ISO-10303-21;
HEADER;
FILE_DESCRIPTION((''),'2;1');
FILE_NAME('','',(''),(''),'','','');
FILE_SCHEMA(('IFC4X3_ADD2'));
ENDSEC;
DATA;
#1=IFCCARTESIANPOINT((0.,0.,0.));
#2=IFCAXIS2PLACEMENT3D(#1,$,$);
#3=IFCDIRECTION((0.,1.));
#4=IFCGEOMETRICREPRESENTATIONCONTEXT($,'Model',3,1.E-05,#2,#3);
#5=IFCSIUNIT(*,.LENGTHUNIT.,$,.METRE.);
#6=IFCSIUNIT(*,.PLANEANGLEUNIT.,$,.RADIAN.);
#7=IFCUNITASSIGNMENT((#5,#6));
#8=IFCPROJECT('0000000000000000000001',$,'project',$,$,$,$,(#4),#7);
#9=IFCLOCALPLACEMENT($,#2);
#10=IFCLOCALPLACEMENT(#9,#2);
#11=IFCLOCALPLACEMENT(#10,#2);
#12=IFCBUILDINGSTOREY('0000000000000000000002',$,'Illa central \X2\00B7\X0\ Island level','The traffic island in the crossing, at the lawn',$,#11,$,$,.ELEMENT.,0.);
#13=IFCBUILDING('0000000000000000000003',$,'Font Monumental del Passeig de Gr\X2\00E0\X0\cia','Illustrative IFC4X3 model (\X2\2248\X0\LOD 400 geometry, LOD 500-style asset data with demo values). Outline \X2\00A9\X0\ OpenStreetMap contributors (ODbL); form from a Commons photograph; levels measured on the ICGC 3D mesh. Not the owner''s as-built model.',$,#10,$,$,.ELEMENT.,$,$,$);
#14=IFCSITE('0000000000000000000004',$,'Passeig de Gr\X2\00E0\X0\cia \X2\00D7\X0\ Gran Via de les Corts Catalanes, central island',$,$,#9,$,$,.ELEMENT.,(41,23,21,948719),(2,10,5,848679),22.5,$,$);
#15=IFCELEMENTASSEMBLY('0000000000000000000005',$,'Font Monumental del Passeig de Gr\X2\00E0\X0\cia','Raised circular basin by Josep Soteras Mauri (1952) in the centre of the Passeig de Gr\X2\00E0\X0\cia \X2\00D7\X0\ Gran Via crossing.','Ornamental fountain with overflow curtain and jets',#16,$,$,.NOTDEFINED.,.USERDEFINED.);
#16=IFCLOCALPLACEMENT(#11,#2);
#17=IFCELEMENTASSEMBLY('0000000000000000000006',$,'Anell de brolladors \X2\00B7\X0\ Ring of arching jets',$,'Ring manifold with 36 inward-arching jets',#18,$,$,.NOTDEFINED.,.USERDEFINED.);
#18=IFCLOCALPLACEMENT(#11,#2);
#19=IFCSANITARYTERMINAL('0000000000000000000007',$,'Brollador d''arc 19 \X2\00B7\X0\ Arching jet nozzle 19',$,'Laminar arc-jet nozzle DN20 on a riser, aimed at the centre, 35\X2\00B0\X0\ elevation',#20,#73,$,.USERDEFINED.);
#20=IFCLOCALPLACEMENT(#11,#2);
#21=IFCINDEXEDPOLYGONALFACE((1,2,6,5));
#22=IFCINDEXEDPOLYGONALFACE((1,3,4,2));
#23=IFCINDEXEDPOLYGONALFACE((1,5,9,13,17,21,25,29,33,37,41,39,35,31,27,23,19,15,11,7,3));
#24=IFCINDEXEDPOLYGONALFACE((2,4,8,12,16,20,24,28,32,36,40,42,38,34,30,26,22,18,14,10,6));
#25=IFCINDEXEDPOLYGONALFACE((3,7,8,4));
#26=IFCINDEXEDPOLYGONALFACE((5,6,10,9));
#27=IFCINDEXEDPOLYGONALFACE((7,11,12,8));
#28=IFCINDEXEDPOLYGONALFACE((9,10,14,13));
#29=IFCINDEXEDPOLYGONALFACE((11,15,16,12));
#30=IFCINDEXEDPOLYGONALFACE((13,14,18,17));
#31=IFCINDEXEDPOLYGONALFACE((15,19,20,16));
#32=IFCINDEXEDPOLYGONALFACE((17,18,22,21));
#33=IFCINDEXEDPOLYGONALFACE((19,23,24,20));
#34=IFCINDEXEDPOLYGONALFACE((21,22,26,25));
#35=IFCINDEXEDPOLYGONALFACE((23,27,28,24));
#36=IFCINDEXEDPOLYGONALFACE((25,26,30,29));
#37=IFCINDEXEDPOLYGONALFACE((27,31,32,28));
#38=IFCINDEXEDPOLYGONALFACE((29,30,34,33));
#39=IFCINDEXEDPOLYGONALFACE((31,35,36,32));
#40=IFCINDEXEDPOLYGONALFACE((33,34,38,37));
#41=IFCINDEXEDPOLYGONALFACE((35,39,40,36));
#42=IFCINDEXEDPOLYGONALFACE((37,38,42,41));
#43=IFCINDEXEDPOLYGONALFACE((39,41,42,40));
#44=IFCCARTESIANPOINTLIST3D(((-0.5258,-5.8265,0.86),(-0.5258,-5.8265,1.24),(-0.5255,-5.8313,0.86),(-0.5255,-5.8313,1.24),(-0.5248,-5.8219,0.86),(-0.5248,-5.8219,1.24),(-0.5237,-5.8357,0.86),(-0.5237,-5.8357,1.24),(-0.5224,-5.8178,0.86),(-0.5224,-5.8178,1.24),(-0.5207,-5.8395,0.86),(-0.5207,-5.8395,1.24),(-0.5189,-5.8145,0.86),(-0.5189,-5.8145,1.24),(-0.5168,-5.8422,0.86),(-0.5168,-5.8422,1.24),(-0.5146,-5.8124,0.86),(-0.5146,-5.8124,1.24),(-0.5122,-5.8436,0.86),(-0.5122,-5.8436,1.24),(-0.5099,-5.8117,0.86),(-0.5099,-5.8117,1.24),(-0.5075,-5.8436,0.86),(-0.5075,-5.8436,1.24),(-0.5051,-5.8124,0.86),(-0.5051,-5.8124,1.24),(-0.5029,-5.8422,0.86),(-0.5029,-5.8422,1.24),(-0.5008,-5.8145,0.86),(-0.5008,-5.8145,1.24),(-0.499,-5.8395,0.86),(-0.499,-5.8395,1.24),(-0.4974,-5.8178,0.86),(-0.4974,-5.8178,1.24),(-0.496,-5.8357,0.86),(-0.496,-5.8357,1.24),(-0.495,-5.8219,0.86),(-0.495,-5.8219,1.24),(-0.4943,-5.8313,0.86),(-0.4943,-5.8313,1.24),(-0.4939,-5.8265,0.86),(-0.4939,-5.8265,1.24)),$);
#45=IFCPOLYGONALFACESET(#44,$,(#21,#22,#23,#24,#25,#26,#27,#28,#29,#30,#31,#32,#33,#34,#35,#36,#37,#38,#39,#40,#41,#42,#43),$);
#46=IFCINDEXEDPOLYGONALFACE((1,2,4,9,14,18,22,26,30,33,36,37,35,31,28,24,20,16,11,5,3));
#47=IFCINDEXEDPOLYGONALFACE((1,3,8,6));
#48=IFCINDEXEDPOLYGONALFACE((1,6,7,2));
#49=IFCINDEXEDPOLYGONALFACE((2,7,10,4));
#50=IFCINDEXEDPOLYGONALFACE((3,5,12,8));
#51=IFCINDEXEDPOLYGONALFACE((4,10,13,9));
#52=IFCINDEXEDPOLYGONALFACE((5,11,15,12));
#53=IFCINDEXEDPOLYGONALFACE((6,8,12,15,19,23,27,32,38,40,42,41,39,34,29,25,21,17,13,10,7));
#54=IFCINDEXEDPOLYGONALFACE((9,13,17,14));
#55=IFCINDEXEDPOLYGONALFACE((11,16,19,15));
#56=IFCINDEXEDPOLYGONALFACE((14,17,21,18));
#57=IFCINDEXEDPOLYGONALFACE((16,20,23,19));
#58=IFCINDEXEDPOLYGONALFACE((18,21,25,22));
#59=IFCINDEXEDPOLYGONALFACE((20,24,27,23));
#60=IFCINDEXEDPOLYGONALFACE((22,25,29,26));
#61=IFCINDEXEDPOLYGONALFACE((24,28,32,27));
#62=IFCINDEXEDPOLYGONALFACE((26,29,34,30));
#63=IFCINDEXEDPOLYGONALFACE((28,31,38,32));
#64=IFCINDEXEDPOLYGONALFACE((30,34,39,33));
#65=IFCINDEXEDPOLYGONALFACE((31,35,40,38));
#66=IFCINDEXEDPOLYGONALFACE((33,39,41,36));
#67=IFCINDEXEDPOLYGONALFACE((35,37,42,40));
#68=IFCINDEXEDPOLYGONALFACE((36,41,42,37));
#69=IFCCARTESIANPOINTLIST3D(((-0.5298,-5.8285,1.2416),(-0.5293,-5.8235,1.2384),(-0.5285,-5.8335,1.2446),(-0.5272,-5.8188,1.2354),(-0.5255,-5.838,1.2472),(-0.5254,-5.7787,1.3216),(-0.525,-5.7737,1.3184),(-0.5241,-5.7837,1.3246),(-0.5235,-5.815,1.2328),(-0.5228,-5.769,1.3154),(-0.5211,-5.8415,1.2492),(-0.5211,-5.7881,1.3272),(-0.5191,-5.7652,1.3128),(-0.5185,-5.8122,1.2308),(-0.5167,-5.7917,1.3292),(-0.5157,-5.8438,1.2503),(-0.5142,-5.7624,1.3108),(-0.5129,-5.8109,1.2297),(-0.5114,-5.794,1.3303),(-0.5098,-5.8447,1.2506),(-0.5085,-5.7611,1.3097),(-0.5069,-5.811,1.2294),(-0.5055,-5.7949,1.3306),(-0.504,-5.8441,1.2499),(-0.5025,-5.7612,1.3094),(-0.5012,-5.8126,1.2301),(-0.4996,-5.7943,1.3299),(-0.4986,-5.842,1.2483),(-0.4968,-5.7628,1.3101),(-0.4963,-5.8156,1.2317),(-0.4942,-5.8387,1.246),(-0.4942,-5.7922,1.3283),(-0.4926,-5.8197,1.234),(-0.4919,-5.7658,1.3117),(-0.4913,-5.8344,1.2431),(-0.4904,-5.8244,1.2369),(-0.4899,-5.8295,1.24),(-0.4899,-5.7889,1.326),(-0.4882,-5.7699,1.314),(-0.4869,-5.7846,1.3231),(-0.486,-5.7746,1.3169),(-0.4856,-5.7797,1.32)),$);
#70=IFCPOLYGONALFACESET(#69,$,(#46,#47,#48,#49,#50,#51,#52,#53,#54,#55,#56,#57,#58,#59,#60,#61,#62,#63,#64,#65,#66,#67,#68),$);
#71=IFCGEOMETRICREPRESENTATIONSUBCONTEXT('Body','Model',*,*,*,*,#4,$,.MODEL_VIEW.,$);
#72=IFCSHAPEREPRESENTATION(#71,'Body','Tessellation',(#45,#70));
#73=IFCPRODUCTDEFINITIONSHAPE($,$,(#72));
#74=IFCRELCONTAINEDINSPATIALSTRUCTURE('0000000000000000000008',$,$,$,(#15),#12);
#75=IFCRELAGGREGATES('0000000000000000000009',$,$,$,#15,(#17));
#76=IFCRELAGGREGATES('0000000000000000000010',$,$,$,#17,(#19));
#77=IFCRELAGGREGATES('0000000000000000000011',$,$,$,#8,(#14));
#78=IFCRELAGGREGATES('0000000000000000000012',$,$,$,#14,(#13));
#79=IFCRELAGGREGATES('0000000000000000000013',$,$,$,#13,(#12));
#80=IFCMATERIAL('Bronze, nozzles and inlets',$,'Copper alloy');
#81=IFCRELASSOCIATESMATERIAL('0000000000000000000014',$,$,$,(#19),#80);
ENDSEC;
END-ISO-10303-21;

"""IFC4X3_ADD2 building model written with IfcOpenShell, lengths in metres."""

from ifc_helpers import new_model, si_unit, direction, frame, origin, origin_2d_with_axis, place, context, subcontext, project, spatial, circle, extrude, material, element, aggregate, save


model = new_model("IFC4X3_ADD2")

# Units and contexts
model_context = context("Model", 3, precision=1e-05, world=origin(), true_north=direction((0.0, 1.0)))
body_context = subcontext(model_context, "Body", "Model", "MODEL_VIEW")
ifc_project = project(units=[si_unit("LENGTHUNIT", "METRE"), si_unit("PLANEANGLEUNIT", "RADIAN")], contexts=[model_context])

# Site, building, storey
site_placement = place(None, origin())
site = spatial("IfcSite", under=ifc_project, at=site_placement, Name="Passeig de Gràcia × Gran Via de les Corts Catalanes, central island", CompositionType="ELEMENT", RefLatitude=(41, 23, 21, 948719), RefLongitude=(2, 10, 5, 848679), RefElevation=22.5)
building_placement = place(site_placement, origin())
building = spatial("IfcBuilding", under=site, at=building_placement, Name="Font Monumental del Passeig de Gràcia", Description="Illustrative IFC4X3 model (≈LOD 400 geometry, LOD 500-style asset data with demo values). Outline © OpenStreetMap contributors (ODbL); form from a Commons photograph; levels measured on the ICGC 3D mesh. Not the owner's as-built model.", CompositionType="ELEMENT")
storey_placement = place(building_placement, origin())
storey = spatial("IfcBuildingStorey", under=building, at=storey_placement, Name="Illa central · Island level", Description="The traffic island in the crossing, at the lawn", CompositionType="ELEMENT", Elevation=0.0)

# Element assemblies, sanitary terminal
assembly_1_placement = place(building_placement, origin())
assembly_1 = element("IfcElementAssembly", 1, at=assembly_1_placement, inside=storey, Name="Font Monumental del Passeig de Gràcia", Description="Raised circular basin by Josep Soteras Mauri (1952) in the centre of the Passeig de Gràcia × Gran Via crossing.", ObjectType="Ornamental fountain with overflow curtain and jets", AssemblyPlace="NOTDEFINED", PredefinedType="USERDEFINED")
assembly_2_placement = place(building_placement, origin())
assembly_2 = element("IfcElementAssembly", 2, at=assembly_2_placement, Name="Anell de brolladors · Ring of arching jets", ObjectType="Ring manifold with 36 inward-arching jets", AssemblyPlace="NOTDEFINED", PredefinedType="USERDEFINED")
aggregate(assembly_1, [assembly_2])
ifc_material_1 = material(Name="Bronze, nozzles and inlets", Category="Copper alloy")
sanitary_terminal_1_placement = place(building_placement, origin())
sanitary_terminal_1 = element("IfcSanitaryTerminal", 3, at=sanitary_terminal_1_placement, material=ifc_material_1, Name="Brollador d'arc 19 · Arching jet nozzle 19", ObjectType="Laminar arc-jet nozzle DN20 on a riser, aimed at the centre, 35° elevation", PredefinedType="USERDEFINED", context=body_context, shape_type="SweptSolid", body=[
    extrude(circle(Radius=0.016, at=origin_2d_with_axis()), frame((-0.5099, -5.8277, 0.86), z_axis=(0.0, 0.0, 1.0), x_axis=(0.0, 1.0, 0.0)), (0.0, 0.0, 1.0), 0.38),
    extrude(circle(Radius=0.02, at=origin_2d_with_axis()), frame((-0.5099, -5.8277, 1.24), z_axis=(0.046192, 0.527982, 0.847998), x_axis=(0.996195, -0.087156, 0.0)), (0.0, 0.0, 1.0), 0.0943),
])
aggregate(assembly_2, [sanitary_terminal_1])

save(model, "model.ifc")
